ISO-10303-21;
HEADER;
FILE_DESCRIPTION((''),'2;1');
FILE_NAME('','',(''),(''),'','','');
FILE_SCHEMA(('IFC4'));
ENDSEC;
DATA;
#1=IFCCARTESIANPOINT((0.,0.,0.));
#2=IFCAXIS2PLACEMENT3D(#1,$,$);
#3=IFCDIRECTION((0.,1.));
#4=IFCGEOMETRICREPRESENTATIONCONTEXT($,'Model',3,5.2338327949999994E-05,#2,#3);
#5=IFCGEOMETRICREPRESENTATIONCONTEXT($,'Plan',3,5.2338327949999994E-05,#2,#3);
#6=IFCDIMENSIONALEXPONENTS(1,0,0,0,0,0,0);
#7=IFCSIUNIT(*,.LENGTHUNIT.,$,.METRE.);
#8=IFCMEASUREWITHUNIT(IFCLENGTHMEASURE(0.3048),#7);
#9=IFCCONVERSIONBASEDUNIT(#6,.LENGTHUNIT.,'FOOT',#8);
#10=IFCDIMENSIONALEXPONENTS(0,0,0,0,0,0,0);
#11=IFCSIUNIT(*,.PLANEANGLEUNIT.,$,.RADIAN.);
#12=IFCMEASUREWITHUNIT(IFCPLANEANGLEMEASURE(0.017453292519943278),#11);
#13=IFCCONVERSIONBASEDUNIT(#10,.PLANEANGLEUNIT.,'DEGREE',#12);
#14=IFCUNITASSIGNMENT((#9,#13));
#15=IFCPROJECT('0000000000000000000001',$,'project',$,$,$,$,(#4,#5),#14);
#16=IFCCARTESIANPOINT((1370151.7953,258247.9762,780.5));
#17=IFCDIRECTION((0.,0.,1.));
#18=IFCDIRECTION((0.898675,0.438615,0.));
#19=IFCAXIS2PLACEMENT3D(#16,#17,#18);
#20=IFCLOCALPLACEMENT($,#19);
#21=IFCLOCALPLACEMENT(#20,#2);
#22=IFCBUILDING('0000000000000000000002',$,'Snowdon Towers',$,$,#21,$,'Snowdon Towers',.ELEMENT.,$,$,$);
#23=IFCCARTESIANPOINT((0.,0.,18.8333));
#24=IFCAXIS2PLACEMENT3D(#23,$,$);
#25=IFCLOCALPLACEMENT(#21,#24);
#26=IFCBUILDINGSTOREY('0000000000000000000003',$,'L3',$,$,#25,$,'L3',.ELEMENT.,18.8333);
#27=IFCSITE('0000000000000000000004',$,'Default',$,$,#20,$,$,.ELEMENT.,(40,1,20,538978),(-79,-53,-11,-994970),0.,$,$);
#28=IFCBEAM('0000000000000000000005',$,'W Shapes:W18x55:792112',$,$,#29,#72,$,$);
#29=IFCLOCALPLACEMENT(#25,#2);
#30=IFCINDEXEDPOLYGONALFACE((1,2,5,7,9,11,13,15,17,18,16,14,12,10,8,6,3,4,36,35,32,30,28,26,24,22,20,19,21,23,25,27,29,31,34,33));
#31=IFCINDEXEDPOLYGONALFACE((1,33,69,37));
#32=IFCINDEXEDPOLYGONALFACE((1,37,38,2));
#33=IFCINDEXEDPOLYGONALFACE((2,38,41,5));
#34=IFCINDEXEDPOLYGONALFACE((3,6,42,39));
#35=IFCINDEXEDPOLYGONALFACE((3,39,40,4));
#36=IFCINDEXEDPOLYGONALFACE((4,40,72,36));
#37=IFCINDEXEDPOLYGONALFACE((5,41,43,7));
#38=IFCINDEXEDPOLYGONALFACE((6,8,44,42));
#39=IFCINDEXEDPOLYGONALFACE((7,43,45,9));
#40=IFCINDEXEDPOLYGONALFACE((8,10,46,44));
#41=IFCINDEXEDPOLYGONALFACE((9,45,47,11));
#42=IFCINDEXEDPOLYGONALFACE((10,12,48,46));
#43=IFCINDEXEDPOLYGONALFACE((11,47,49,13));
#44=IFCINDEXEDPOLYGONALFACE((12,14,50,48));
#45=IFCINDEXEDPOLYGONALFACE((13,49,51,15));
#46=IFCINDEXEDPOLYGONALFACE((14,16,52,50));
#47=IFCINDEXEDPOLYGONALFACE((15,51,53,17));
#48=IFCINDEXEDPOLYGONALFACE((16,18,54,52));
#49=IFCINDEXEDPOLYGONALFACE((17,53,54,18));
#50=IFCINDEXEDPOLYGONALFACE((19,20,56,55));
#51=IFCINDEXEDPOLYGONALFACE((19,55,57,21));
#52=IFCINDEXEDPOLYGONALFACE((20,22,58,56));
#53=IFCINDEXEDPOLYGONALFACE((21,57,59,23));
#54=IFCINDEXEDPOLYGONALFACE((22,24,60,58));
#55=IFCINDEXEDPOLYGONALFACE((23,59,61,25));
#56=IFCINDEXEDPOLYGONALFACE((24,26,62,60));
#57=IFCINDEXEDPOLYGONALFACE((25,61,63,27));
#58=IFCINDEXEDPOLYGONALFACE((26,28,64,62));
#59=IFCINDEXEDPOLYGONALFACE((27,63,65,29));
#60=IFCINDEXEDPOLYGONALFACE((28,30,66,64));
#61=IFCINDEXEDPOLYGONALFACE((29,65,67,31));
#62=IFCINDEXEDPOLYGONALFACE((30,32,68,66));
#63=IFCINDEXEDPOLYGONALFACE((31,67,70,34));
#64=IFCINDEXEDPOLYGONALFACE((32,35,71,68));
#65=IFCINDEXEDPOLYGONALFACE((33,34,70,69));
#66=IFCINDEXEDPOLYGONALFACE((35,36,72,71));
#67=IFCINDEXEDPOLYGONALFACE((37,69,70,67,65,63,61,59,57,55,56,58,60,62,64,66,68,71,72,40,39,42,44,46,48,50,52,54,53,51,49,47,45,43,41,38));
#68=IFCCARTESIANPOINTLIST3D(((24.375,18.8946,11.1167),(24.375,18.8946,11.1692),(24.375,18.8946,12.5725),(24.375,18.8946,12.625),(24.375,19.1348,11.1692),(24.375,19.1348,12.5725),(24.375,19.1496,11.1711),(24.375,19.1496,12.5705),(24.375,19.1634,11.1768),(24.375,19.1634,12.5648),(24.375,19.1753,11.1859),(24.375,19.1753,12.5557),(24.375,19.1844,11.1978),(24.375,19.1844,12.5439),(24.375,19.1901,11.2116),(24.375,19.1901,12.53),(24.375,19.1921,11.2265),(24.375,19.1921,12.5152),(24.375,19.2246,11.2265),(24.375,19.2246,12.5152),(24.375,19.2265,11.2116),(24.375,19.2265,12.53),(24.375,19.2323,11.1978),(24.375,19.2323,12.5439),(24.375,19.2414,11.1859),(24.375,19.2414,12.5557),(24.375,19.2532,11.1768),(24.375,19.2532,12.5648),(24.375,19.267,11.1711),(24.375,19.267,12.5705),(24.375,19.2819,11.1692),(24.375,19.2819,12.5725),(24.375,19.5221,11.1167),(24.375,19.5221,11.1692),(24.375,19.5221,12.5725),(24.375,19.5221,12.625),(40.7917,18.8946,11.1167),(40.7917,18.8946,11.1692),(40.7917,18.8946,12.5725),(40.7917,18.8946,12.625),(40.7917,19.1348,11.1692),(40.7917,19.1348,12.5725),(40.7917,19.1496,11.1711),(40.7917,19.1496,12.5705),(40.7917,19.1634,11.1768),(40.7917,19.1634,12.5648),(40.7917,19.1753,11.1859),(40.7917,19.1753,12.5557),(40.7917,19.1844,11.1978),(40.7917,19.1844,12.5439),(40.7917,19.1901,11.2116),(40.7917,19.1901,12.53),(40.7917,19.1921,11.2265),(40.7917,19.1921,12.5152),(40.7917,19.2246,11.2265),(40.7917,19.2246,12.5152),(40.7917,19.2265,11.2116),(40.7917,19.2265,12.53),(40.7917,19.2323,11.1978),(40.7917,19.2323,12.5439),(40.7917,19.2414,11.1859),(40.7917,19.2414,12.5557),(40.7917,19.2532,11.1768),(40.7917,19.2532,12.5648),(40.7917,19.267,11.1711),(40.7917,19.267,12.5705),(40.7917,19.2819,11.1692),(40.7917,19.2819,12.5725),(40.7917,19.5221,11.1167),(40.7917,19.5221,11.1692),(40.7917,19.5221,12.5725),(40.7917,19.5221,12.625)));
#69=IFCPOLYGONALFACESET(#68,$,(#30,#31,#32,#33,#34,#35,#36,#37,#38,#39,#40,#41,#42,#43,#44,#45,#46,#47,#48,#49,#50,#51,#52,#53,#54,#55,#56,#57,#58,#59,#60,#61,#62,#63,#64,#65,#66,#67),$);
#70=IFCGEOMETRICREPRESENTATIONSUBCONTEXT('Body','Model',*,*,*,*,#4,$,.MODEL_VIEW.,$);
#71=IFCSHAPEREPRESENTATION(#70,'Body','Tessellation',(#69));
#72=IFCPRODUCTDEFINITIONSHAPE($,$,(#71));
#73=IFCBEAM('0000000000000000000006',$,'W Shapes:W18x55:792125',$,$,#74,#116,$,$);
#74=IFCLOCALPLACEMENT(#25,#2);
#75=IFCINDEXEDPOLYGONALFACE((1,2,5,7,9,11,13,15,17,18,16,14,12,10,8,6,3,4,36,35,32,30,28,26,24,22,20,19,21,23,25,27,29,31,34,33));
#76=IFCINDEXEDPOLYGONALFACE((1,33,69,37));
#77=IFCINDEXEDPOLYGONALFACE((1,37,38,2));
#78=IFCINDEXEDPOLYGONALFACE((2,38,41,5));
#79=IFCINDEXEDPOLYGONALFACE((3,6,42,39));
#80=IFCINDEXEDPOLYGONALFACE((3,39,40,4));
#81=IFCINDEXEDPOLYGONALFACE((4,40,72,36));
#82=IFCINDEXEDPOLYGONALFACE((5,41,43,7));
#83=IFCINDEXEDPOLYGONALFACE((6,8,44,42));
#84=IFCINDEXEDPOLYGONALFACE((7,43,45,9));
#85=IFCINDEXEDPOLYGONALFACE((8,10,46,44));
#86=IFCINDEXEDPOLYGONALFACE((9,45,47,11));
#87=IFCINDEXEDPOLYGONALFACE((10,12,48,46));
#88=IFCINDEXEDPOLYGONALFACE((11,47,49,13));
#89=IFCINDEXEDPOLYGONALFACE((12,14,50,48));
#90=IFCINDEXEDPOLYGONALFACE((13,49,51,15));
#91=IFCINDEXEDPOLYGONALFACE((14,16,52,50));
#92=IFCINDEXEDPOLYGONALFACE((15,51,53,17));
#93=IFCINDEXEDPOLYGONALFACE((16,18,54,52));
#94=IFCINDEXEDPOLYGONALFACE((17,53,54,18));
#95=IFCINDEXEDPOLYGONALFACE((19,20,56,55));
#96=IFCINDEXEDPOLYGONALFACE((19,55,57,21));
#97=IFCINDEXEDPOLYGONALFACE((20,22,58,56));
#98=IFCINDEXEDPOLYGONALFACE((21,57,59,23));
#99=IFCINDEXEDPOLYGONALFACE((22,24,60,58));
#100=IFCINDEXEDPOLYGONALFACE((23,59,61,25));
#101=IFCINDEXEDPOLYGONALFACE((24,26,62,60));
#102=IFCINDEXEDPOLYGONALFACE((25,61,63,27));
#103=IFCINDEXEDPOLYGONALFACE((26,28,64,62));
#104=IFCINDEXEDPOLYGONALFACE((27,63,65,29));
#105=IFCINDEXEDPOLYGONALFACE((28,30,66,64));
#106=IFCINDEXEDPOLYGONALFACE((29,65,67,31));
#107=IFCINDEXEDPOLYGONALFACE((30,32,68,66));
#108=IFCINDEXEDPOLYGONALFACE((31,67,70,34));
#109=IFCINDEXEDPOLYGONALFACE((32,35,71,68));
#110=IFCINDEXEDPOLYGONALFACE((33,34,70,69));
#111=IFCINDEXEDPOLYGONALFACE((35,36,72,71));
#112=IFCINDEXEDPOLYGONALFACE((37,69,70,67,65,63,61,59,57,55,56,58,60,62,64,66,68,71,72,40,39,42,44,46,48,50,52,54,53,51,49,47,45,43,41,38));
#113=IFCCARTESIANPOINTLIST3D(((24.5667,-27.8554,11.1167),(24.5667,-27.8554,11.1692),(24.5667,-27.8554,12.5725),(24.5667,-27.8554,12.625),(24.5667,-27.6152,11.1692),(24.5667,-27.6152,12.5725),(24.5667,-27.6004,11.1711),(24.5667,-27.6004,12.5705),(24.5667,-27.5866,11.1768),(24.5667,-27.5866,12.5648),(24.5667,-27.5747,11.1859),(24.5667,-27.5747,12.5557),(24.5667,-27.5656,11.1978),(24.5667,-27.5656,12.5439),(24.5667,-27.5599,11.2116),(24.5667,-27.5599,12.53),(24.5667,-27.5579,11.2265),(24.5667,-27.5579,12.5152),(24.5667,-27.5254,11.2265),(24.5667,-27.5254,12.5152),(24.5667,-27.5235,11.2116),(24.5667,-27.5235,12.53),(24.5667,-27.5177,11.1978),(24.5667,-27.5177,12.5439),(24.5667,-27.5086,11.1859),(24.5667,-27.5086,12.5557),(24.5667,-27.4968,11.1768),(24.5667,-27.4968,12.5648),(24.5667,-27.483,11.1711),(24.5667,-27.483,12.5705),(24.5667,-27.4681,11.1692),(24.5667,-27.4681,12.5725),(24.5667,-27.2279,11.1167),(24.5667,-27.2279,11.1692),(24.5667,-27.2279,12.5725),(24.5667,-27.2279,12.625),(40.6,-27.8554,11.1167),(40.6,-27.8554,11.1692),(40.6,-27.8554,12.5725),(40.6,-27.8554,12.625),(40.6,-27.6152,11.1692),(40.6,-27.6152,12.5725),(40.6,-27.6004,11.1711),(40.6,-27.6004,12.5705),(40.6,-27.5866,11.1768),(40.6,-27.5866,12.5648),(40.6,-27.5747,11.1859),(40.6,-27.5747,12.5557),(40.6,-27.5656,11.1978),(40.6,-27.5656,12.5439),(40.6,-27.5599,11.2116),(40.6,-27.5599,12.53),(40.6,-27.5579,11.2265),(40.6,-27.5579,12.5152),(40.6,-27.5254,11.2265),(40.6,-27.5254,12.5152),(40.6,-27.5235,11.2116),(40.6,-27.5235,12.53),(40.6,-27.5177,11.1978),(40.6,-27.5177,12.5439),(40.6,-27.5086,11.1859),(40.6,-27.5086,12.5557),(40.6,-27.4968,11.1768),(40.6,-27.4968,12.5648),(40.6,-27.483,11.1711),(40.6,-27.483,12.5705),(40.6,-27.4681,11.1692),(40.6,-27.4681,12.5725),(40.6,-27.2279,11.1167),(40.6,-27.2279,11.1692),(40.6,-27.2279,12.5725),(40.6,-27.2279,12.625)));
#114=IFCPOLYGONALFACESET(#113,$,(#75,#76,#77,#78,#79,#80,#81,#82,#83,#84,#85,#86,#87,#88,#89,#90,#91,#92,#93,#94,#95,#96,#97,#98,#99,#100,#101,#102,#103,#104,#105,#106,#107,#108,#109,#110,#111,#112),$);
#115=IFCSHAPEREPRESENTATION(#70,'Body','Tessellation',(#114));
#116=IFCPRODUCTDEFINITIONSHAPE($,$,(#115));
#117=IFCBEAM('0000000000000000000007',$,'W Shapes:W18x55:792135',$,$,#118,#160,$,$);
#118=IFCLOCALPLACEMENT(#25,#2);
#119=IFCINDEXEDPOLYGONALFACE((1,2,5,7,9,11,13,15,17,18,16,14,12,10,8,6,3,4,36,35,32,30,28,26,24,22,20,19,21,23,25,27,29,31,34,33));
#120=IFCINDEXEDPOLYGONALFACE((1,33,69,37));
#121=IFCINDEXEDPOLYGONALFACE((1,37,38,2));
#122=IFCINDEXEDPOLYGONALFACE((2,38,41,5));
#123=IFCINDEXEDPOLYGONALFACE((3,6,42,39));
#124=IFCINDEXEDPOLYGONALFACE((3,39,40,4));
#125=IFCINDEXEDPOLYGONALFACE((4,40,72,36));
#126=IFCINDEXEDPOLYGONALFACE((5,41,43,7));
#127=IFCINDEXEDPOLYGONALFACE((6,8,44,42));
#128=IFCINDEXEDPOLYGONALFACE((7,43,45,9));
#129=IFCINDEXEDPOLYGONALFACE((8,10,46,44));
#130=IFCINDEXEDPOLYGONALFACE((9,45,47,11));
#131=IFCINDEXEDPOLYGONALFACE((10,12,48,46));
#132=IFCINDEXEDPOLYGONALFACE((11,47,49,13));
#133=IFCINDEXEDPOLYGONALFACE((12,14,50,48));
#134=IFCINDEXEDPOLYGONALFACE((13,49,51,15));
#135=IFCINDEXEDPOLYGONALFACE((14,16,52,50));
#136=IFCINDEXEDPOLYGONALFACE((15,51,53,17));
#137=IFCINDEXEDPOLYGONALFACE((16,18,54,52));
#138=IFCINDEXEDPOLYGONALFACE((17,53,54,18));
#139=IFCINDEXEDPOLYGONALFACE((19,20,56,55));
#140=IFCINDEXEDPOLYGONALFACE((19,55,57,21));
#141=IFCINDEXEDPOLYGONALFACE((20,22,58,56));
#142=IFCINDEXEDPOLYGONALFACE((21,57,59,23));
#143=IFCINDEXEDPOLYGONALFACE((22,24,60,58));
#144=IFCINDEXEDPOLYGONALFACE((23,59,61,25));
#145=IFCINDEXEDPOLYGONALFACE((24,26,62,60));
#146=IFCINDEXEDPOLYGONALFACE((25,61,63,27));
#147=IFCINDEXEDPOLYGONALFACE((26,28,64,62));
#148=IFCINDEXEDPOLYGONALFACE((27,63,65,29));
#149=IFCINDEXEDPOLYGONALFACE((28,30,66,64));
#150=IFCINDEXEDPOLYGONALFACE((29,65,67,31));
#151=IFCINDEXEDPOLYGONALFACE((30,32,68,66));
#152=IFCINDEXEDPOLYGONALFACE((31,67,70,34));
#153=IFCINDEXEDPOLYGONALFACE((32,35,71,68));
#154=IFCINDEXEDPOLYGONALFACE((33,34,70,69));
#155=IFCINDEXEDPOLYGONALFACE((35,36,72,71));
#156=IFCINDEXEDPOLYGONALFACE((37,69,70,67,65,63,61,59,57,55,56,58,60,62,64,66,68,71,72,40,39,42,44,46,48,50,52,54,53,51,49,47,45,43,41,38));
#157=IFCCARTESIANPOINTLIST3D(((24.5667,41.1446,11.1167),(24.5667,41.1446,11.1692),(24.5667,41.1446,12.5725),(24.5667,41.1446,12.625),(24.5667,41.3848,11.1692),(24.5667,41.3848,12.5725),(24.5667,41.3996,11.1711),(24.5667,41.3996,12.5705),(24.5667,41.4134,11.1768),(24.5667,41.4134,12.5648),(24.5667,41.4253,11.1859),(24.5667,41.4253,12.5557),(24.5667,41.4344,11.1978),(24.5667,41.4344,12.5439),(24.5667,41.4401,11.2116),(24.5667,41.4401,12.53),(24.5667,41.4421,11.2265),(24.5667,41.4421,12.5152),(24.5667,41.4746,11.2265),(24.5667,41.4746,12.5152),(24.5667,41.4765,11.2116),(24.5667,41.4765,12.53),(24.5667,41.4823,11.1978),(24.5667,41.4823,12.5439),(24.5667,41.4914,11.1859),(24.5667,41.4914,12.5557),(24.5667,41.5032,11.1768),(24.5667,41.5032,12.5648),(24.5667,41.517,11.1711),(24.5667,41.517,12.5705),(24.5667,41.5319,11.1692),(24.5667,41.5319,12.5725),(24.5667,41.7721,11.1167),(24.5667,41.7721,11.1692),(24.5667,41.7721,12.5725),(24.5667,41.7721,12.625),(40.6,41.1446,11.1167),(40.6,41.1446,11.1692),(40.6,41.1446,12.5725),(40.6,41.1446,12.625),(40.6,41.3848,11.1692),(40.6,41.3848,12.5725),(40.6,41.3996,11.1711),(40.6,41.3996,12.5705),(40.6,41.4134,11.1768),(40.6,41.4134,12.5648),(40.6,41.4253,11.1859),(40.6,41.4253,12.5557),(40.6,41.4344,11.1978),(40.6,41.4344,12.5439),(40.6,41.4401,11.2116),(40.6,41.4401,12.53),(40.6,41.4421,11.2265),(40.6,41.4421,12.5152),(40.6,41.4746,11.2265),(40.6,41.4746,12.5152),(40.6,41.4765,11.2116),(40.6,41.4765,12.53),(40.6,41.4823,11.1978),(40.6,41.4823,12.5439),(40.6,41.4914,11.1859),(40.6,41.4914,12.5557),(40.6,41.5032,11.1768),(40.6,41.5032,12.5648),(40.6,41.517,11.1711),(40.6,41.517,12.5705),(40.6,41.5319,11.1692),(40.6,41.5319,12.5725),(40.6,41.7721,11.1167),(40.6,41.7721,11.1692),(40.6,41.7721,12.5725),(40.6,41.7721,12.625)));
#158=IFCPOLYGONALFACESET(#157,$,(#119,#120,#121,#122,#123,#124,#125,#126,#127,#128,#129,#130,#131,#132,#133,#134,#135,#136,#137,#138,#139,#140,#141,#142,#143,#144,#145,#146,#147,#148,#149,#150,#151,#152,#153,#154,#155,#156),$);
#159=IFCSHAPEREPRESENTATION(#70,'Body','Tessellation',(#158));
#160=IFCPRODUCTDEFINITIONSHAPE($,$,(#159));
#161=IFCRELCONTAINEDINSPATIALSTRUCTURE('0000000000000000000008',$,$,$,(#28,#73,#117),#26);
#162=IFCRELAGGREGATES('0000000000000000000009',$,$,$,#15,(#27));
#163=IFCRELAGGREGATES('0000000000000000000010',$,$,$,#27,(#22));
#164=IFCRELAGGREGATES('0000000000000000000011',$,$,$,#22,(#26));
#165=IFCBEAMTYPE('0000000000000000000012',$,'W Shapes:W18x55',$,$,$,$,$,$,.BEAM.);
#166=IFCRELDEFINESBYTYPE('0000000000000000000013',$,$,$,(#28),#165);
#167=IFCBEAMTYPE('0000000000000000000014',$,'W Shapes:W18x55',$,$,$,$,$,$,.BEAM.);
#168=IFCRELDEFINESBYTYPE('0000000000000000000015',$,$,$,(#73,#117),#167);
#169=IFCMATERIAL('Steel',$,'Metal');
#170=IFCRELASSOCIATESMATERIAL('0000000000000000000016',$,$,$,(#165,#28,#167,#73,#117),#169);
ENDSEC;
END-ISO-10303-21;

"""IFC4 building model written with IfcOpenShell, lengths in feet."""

from ifc_helpers import new_model, entity, si_unit, converted_unit, direction, frame, origin, place, context, subcontext, project, spatial, line, arc, indexed_curve, outline, extrude, source, transform, mapped, material, type_object, type_shapes, element, save


model = new_model("IFC4")

# Units and contexts
model_context = context("Model", 3, precision=5.2338327949999994e-05, world=origin(), true_north=direction((0.0, 1.0)))
plan_context = context("Plan", 3, precision=5.2338327949999994e-05, world=origin(), true_north=direction((0.0, 1.0)))
body_context = subcontext(model_context, "Body", "Model", "MODEL_VIEW")
ifc_project = project(units=[converted_unit("LENGTHUNIT", "FOOT", entity("IfcLengthMeasure", 0.3048), si_unit("LENGTHUNIT", "METRE"), dimensions=[1, 0, 0, 0, 0, 0, 0]), converted_unit("PLANEANGLEUNIT", "DEGREE", entity("IfcPlaneAngleMeasure", 0.017453292519943278), si_unit("PLANEANGLEUNIT", "RADIAN"), dimensions=[0, 0, 0, 0, 0, 0, 0])], contexts=[model_context, plan_context])

# Site, building, storey
site_placement = place(None, frame((1370151.7953, 258247.9762, 780.5), z_axis=(0.0, 0.0, 1.0), x_axis=(0.898675, 0.438615, 0.0)))
site = spatial("IfcSite", under=ifc_project, at=site_placement, Name="Default", CompositionType="ELEMENT", RefLatitude=(40, 1, 20, 538978), RefLongitude=(-79, -53, -11, -994970), RefElevation=0.0)
building_placement = place(site_placement, origin())
building = spatial("IfcBuilding", under=site, at=building_placement, Name="Snowdon Towers", LongName="Snowdon Towers", CompositionType="ELEMENT")
storey_placement = place(building_placement, frame((0.0, 0.0, 18.8333)))
storey = spatial("IfcBuildingStorey", under=building, at=storey_placement, Name="L3", LongName="L3", CompositionType="ELEMENT", Elevation=18.8333)

# Beams
ifc_material_1 = material(Name="Steel", Category="Metal")
beam_type_1 = type_object("IfcBeamType", Name="W Shapes:W18x55", PredefinedType="BEAM", material=ifc_material_1)
shared_shape_1 = source(origin(), body_context, "Body", "SweptSolid", [
    extrude(outline(indexed_curve([(-0.7542, -0.3138), (-0.7017, -0.3138), (-0.7017, -0.0735), (-0.6849, -0.033), (-0.6444, -0.0162), (0.6444, -0.0162), (0.6849, -0.033), (0.7017, -0.0735), (0.7017, -0.3138), (0.7542, -0.3138), (0.7542, 0.3138), (0.7017, 0.3138), (0.7017, 0.0735), (0.6849, 0.033), (0.6444, 0.0163), (-0.6444, 0.0163), (-0.6849, 0.033), (-0.7017, 0.0735), (-0.7017, 0.3137), (-0.7542, 0.3137)], segments=[line(1, 2, 3), arc(3, 4, 5), line(5, 6), arc(6, 7, 8), line(8, 9, 10, 11, 12, 13), arc(13, 14, 15), line(15, 16), arc(16, 17, 18), line(18, 19, 20, 1)], self_intersect=False)), frame((-8.2083, 0.0, 0.0), z_axis=(1.0, 0.0, 0.0), x_axis=(0.0, 0.0, -1.0)), (0.0, 0.0, 1.0), 16.4167),
])
type_shapes(beam_type_1, [shared_shape_1])
beam_1_placement = place(storey_placement, frame((32.5833, 19.2083, 11.8708)))
element("IfcBeam", 1, at=beam_1_placement, inside=storey, type_object=beam_type_1, material=ifc_material_1, Name="W Shapes:W18x55:792112", context=body_context, shape_type="MappedRepresentation", body=[
    mapped(shared_shape_1, transform((0.0, 0.0, 0.0), scale=1.0)),
])
beam_type_2 = type_object("IfcBeamType", Name="W Shapes:W18x55", PredefinedType="BEAM", material=ifc_material_1)
shared_shape_2 = source(origin(), body_context, "Body", "SweptSolid", [
    extrude(outline(indexed_curve([(-0.7542, -0.3138), (-0.7017, -0.3138), (-0.7017, -0.0735), (-0.6849, -0.033), (-0.6444, -0.0162), (0.6444, -0.0162), (0.6849, -0.033), (0.7017, -0.0735), (0.7017, -0.3138), (0.7542, -0.3138), (0.7542, 0.3138), (0.7017, 0.3138), (0.7017, 0.0735), (0.6849, 0.033), (0.6444, 0.0163), (-0.6444, 0.0163), (-0.6849, 0.033), (-0.7017, 0.0735), (-0.7017, 0.3137), (-0.7542, 0.3137)], segments=[line(1, 2, 3), arc(3, 4, 5), line(5, 6), arc(6, 7, 8), line(8, 9, 10, 11, 12, 13), arc(13, 14, 15), line(15, 16), arc(16, 17, 18), line(18, 19, 20, 1)], self_intersect=False)), frame((-8.0167, 0.0, 0.0), z_axis=(1.0, 0.0, 0.0), x_axis=(0.0, 0.0, -1.0)), (0.0, 0.0, 1.0), 16.0333),
])
type_shapes(beam_type_2, [shared_shape_2])
for number, where, name in (
    (2, (32.5833, -27.5417, 11.8708), "W Shapes:W18x55:792125"),
    (3, (32.5833, 41.4583, 11.8708), "W Shapes:W18x55:792135"),
):
    element("IfcBeam", number, at=place(storey_placement, frame(where)), inside=storey, type_object=beam_type_2, material=ifc_material_1, Name=name, context=body_context, shape_type="MappedRepresentation", body=[
        mapped(shared_shape_2, transform((0.0, 0.0, 0.0), scale=1.0)),
    ])

save(model, "model.ifc")
